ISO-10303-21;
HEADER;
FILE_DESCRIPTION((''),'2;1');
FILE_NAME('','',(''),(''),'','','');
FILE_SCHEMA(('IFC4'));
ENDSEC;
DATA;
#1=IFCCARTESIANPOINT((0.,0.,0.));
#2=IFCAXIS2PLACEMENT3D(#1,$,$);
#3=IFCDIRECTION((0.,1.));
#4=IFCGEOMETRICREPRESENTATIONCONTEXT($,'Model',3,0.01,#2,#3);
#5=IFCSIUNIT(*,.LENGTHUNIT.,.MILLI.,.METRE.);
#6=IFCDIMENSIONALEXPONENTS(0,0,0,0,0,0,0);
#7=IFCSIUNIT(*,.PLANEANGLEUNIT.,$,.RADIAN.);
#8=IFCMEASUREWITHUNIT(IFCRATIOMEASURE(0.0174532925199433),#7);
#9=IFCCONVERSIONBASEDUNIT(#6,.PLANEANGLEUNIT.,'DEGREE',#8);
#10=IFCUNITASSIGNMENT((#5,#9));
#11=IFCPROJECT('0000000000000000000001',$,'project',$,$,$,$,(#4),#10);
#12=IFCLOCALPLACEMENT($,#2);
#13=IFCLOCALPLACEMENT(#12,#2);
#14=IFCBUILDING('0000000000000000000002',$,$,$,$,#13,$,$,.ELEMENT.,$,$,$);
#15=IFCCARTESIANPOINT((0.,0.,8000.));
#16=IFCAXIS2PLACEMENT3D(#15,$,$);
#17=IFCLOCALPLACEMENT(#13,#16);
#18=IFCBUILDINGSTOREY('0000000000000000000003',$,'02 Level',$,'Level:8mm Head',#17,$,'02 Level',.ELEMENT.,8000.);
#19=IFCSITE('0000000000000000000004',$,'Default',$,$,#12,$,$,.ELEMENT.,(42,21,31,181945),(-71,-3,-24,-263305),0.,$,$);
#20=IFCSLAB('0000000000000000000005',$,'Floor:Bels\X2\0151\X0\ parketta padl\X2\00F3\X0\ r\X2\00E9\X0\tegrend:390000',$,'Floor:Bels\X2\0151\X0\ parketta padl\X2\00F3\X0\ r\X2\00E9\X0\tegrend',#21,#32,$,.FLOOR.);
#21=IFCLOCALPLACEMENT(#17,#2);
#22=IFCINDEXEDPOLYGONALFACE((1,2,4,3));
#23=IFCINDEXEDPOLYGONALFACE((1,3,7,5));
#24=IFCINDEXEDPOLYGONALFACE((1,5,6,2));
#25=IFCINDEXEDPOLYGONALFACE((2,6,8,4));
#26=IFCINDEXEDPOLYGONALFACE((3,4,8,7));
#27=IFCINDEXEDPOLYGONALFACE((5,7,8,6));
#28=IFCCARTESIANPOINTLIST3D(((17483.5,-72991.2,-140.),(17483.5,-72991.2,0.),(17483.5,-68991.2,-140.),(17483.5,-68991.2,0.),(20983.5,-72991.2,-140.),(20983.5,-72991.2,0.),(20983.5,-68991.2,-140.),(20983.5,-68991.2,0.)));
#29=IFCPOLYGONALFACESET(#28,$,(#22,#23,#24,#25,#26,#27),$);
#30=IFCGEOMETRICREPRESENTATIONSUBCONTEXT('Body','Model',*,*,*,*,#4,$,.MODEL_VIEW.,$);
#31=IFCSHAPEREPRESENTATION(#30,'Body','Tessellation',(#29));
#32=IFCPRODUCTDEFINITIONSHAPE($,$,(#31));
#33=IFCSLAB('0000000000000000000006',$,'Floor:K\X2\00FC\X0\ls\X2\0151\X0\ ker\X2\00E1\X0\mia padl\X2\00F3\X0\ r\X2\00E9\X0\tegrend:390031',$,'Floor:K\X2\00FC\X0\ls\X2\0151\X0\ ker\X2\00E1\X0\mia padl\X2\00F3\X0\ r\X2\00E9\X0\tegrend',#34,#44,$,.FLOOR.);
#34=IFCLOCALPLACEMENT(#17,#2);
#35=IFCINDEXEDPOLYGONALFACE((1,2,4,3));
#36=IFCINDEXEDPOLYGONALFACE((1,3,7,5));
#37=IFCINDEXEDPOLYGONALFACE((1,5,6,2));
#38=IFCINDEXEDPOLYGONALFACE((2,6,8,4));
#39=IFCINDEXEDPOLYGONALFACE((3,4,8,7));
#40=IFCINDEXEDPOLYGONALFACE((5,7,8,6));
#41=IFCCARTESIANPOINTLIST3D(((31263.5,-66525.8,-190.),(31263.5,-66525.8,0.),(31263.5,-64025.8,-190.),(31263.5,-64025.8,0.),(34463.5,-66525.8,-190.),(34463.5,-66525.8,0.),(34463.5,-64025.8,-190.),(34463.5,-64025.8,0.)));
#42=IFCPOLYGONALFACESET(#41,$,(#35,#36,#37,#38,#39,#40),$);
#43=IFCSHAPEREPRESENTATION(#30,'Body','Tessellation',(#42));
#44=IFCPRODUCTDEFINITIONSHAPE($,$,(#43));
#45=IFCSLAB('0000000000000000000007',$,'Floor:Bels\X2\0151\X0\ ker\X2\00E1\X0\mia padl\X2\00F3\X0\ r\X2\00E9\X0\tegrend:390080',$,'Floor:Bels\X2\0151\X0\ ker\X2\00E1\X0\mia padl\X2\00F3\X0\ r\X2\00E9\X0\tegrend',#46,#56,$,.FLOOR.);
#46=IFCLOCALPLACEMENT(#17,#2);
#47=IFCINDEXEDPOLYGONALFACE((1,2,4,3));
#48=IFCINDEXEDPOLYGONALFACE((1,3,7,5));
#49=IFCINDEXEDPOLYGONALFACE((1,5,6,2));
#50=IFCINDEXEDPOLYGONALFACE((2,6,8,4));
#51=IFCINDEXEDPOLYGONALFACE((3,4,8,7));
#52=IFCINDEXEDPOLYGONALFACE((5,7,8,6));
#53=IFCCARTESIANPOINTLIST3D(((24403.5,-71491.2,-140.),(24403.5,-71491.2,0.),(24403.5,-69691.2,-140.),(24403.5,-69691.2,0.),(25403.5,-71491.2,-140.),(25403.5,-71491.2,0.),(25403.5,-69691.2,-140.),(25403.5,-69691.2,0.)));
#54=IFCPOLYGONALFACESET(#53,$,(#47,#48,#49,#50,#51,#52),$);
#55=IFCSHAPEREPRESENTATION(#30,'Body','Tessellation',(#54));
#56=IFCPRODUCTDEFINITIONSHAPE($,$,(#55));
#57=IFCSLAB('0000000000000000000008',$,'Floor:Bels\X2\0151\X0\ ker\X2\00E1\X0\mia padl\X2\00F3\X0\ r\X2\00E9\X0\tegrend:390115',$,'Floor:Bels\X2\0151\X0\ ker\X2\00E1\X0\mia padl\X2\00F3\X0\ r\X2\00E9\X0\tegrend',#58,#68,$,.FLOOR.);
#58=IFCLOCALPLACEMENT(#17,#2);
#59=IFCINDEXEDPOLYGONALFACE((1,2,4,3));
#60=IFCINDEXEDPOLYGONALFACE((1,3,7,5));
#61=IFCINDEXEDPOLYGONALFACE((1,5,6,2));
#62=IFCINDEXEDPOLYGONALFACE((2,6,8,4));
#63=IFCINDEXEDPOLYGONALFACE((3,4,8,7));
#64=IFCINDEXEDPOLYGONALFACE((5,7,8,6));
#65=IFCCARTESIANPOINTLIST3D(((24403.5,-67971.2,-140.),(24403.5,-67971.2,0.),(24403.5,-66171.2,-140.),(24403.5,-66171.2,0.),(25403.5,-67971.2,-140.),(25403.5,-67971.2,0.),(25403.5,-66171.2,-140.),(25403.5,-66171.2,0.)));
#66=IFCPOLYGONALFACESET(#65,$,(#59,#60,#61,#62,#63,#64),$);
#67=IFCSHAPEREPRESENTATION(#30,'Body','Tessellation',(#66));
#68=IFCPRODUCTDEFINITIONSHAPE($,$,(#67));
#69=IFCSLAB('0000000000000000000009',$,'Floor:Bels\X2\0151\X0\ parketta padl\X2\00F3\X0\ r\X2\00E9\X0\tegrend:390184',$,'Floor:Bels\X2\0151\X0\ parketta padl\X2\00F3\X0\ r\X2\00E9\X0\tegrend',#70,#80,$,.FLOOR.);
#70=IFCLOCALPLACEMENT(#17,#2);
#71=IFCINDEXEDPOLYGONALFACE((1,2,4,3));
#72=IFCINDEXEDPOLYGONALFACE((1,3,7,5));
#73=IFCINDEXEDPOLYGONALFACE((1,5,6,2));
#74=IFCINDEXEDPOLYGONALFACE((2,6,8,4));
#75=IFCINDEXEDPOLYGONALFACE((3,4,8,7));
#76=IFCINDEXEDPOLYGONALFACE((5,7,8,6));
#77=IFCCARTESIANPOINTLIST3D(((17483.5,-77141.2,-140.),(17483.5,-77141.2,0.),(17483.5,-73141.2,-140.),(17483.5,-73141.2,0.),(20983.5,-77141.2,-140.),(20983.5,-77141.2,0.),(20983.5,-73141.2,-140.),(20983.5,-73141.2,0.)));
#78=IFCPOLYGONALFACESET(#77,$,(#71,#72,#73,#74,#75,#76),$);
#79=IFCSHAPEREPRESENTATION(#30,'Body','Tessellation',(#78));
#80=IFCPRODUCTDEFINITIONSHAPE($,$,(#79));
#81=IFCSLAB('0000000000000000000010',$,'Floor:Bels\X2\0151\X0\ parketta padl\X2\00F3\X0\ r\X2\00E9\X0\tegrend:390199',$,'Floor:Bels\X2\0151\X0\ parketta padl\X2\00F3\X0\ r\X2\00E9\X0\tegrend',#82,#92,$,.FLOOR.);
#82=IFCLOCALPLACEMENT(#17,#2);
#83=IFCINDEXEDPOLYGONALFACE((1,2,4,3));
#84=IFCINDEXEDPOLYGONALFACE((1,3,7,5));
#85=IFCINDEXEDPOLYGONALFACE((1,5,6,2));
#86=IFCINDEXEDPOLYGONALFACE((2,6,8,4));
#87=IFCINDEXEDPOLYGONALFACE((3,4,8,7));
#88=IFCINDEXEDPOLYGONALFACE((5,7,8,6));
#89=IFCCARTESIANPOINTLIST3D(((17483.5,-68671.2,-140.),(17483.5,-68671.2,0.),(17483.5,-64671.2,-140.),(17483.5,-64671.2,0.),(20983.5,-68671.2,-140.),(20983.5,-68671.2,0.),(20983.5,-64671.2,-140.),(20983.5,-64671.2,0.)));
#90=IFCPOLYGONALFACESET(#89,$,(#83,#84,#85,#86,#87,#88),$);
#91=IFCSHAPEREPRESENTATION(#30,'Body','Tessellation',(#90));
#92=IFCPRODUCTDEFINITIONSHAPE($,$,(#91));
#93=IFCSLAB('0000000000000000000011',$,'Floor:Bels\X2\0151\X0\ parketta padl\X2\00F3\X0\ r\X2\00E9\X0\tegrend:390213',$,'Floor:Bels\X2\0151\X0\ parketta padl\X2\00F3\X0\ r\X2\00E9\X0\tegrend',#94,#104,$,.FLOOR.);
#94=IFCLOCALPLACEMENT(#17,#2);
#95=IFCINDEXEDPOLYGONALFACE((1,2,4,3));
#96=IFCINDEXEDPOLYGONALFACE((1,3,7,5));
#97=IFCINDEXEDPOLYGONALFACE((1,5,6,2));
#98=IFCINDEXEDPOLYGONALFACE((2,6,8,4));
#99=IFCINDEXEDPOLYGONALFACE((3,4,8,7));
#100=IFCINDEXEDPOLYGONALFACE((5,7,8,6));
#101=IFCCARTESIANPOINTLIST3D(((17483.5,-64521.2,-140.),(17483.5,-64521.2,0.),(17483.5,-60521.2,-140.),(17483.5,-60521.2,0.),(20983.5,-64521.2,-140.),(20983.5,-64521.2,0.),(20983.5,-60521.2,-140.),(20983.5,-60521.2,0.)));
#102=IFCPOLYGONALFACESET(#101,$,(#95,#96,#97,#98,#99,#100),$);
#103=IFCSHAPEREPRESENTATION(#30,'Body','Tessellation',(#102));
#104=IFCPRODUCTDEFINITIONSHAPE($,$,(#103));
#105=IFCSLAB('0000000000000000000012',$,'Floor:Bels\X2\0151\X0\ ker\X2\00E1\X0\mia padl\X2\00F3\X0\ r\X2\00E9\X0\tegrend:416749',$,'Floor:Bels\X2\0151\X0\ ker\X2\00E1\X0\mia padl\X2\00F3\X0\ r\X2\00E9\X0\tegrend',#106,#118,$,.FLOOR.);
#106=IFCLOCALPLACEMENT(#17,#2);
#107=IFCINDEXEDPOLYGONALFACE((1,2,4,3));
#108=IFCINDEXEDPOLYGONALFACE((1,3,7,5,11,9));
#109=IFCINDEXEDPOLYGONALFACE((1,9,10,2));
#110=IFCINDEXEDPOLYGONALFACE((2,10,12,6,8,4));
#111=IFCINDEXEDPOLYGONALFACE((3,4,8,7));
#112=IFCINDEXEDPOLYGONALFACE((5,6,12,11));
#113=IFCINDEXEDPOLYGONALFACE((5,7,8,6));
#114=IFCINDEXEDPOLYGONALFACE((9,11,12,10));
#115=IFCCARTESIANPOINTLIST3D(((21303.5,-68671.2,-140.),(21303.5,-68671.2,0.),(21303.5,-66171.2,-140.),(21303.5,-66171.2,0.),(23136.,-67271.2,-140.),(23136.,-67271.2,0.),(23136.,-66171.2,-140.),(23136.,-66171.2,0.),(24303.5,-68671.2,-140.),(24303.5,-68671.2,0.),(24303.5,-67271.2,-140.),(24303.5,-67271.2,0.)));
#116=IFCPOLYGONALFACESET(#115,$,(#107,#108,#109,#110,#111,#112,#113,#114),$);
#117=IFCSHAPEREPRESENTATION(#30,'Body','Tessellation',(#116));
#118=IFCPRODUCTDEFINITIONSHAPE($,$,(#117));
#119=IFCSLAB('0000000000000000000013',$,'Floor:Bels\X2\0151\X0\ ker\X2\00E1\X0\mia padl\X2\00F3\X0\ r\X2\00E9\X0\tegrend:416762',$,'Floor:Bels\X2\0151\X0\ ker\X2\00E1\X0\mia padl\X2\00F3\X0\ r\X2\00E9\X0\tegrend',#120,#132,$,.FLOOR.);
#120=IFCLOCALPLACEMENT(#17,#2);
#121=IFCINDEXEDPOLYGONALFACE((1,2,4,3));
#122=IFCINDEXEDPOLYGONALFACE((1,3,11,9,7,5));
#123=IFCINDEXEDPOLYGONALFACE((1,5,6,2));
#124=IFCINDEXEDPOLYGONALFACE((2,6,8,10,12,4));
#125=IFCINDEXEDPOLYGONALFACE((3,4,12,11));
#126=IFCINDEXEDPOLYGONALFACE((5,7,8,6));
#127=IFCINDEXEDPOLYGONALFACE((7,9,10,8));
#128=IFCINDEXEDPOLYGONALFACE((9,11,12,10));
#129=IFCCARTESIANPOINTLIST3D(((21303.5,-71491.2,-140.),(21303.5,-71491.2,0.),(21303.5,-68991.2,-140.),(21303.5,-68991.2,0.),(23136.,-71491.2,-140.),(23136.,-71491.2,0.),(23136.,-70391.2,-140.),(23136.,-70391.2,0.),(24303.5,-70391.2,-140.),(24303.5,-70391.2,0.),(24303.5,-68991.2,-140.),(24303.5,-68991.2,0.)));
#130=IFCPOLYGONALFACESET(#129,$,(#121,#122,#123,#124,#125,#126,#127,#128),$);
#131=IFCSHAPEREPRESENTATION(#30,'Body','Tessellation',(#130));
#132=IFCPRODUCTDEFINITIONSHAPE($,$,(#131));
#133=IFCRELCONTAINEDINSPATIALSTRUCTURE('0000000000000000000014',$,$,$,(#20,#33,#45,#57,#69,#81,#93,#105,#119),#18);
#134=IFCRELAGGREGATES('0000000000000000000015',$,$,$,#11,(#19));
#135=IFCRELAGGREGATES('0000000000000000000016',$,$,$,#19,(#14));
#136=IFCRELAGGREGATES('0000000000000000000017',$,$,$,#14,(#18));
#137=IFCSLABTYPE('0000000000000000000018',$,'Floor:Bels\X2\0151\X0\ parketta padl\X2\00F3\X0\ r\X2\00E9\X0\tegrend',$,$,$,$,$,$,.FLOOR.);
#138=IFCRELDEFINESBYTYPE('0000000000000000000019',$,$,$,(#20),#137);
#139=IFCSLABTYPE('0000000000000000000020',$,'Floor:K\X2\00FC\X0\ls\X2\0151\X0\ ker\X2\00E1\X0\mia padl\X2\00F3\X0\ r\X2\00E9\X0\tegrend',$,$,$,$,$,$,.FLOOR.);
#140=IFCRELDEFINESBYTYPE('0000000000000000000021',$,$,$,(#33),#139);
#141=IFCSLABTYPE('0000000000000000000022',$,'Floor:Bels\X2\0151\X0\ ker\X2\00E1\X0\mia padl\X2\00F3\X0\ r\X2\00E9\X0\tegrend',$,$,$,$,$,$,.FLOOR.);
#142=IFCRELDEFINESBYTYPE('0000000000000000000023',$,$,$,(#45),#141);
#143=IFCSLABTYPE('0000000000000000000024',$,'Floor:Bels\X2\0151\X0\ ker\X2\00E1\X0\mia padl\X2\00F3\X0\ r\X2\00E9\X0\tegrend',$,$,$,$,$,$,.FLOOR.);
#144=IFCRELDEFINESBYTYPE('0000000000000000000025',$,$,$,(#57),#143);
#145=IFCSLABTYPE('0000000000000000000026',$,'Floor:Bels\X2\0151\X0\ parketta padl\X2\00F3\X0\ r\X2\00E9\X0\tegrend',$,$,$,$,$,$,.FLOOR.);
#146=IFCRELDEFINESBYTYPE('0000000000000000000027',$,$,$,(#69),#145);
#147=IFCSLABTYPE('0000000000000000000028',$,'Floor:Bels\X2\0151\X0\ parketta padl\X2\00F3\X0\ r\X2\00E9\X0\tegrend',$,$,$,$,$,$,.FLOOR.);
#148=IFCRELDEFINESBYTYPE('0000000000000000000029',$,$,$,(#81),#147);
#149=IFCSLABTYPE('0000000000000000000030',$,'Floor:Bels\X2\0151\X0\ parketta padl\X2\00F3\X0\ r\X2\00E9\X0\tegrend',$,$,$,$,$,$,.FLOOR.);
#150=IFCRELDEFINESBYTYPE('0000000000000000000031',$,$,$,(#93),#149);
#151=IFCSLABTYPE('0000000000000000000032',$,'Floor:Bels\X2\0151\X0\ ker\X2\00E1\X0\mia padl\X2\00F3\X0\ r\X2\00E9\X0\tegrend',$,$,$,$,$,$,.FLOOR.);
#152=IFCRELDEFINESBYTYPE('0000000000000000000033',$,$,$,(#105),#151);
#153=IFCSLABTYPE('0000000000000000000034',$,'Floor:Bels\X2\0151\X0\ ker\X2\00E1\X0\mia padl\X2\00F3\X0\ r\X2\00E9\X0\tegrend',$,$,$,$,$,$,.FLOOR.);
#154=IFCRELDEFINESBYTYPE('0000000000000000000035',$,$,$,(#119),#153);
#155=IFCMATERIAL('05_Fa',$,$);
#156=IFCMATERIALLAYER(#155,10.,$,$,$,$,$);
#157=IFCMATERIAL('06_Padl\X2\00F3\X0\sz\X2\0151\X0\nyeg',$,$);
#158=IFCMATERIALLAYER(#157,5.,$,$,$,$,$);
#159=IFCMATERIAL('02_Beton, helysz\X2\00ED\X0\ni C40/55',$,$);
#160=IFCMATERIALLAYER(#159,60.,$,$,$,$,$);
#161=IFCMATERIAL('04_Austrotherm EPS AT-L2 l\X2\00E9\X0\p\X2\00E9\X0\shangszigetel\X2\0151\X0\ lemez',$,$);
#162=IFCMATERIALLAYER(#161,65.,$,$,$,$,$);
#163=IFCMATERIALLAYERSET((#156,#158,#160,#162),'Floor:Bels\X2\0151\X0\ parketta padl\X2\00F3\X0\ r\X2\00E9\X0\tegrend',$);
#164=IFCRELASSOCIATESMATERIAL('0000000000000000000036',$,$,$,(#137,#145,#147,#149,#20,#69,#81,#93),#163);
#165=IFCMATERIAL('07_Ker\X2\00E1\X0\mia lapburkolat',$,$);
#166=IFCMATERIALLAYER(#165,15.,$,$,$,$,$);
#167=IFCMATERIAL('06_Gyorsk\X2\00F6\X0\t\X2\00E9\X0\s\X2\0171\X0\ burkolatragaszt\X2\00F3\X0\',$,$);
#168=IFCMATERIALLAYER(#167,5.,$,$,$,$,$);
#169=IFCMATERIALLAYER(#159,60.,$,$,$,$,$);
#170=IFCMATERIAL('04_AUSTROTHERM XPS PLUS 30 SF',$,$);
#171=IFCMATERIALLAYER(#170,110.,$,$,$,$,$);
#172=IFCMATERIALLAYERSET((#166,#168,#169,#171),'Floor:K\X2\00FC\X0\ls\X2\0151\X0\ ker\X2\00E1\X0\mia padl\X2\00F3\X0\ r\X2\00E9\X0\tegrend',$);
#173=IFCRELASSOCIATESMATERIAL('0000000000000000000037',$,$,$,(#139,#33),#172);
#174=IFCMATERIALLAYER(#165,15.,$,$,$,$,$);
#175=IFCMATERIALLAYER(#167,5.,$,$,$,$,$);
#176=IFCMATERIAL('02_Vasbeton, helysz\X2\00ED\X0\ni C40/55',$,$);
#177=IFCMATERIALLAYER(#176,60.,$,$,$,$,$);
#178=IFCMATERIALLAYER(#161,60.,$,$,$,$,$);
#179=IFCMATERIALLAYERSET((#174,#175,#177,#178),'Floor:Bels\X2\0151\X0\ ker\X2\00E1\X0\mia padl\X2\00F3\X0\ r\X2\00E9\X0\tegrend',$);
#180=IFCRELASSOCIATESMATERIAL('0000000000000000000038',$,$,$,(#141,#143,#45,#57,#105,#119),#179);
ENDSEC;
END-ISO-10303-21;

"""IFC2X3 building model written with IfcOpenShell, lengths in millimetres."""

from ifc_helpers import new_model, entity, si_unit, converted_unit, direction, frame, frame_2d, origin, origin_2d_with_axis, place, context, subcontext, project, spatial, polyline, rectangle, outline, extrude, material, layer, layer_set, layer_usage, type_object, element, save


model = new_model("IFC2X3")

# Units and contexts
model_context = context("Model", 3, precision=0.01, world=origin(), true_north=direction((0.0, 1.0)))
body_context = subcontext(model_context, "Body", "Model", "MODEL_VIEW")
ifc_project = project(units=[si_unit("LENGTHUNIT", "METRE", prefix="MILLI"), converted_unit("PLANEANGLEUNIT", "DEGREE", entity("IfcRatioMeasure", 0.0174532925199433), si_unit("PLANEANGLEUNIT", "RADIAN"), dimensions=[0, 0, 0, 0, 0, 0, 0])], contexts=[model_context])

# Site, building, storey
site_placement = place(None, origin())
site = spatial("IfcSite", under=ifc_project, at=site_placement, Name="Default", CompositionType="ELEMENT", RefLatitude=(42, 21, 31, 181945), RefLongitude=(-71, -3, -24, -263305), RefElevation=0.0)
building_placement = place(site_placement, origin())
building = spatial("IfcBuilding", under=site, at=building_placement, CompositionType="ELEMENT")
storey_placement = place(building_placement, frame((0.0, 0.0, 8000.0)))
storey = spatial("IfcBuildingStorey", under=building, at=storey_placement, Name="02 Level", ObjectType="Level:8mm Head", LongName="02 Level", CompositionType="ELEMENT", Elevation=8000.0)

# Slabs
ifc_material_1 = material(Name="05_Fa")
ifc_layer_1 = layer(ifc_material_1, 10.0)
ifc_material_2 = material(Name="06_Padlószőnyeg")
ifc_layer_2 = layer(ifc_material_2, 5.0)
ifc_material_3 = material(Name="02_Beton, helyszíni C40/55")
ifc_layer_3 = layer(ifc_material_3, 60.0)
ifc_material_4 = material(Name="04_Austrotherm EPS AT-L2 lépéshangszigetelő lemez")
ifc_layer_4 = layer(ifc_material_4, 65.0)
ifc_layer_set_1 = layer_set([ifc_layer_1, ifc_layer_2, ifc_layer_3, ifc_layer_4], Name="Floor:Belső parketta padló rétegrend")
ifc_layer_usage_1 = layer_usage(ifc_layer_set_1, "AXIS3", "POSITIVE", 0.0)
slab_type_1 = type_object("IfcSlabType", Name="Floor:Belső parketta padló rétegrend", PredefinedType="FLOOR", material=ifc_layer_set_1)
slab_1_placement = place(storey_placement, origin())
element("IfcSlab", 1, at=slab_1_placement, inside=storey, type_object=slab_type_1, material=ifc_layer_usage_1, Name="Floor:Belső parketta padló rétegrend:390000", ObjectType="Floor:Belső parketta padló rétegrend", PredefinedType="FLOOR", context=body_context, shape_type="SweptSolid", body=[
    extrude(rectangle(XDim=4000.0, YDim=3500.0, at=frame_2d((0.0, 0.0), x_axis=(1.0, 0.0))), frame((19233.5, -70991.2, 0.0), z_axis=(0.0, 0.0, -1.0), x_axis=(0.0, 1.0, 0.0)), (0.0, 0.0, 1.0), 140.0),
])
ifc_material_5 = material(Name="07_Kerámia lapburkolat")
ifc_layer_5 = layer(ifc_material_5, 15.0)
ifc_material_6 = material(Name="06_Gyorskötésű burkolatragasztó")
ifc_layer_6 = layer(ifc_material_6, 5.0)
ifc_layer_7 = layer(ifc_material_3, 60.0)
ifc_material_7 = material(Name="04_AUSTROTHERM XPS PLUS 30 SF")
ifc_layer_8 = layer(ifc_material_7, 110.0)
ifc_layer_set_2 = layer_set([ifc_layer_5, ifc_layer_6, ifc_layer_7, ifc_layer_8], Name="Floor:Külső kerámia padló rétegrend")
ifc_layer_usage_2 = layer_usage(ifc_layer_set_2, "AXIS3", "POSITIVE", 0.0)
slab_type_2 = type_object("IfcSlabType", Name="Floor:Külső kerámia padló rétegrend", PredefinedType="FLOOR", material=ifc_layer_set_2)
slab_2_placement = place(storey_placement, origin())
element("IfcSlab", 2, at=slab_2_placement, inside=storey, type_object=slab_type_2, material=ifc_layer_usage_2, Name="Floor:Külső kerámia padló rétegrend:390031", ObjectType="Floor:Külső kerámia padló rétegrend", PredefinedType="FLOOR", context=body_context, shape_type="SweptSolid", body=[
    extrude(rectangle(XDim=2500.0, YDim=3200.0, at=origin_2d_with_axis()), frame((32863.5, -65275.8, 0.0), z_axis=(0.0, 0.0, -1.0), x_axis=(0.0, 1.0, 0.0)), (0.0, 0.0, 1.0), 190.0),
])
ifc_layer_9 = layer(ifc_material_5, 15.0)
ifc_layer_10 = layer(ifc_material_6, 5.0)
ifc_material_8 = material(Name="02_Vasbeton, helyszíni C40/55")
ifc_layer_11 = layer(ifc_material_8, 60.0)
ifc_layer_12 = layer(ifc_material_4, 60.0)
ifc_layer_set_3 = layer_set([ifc_layer_9, ifc_layer_10, ifc_layer_11, ifc_layer_12], Name="Floor:Belső kerámia padló rétegrend")
ifc_layer_usage_3 = layer_usage(ifc_layer_set_3, "AXIS3", "POSITIVE", 0.0)
slab_type_3 = type_object("IfcSlabType", Name="Floor:Belső kerámia padló rétegrend", PredefinedType="FLOOR", material=ifc_layer_set_3)
slab_3_placement = place(storey_placement, origin())
element("IfcSlab", 3, at=slab_3_placement, inside=storey, type_object=slab_type_3, material=ifc_layer_usage_3, Name="Floor:Belső kerámia padló rétegrend:390080", ObjectType="Floor:Belső kerámia padló rétegrend", PredefinedType="FLOOR", context=body_context, shape_type="SweptSolid", body=[
    extrude(rectangle(XDim=1800.0, YDim=1000.0, at=frame_2d((0.0, 0.0), x_axis=(1.0, 0.0))), frame((24903.5, -70591.2, 0.0), z_axis=(0.0, 0.0, -1.0), x_axis=(0.0, 1.0, 0.0)), (0.0, 0.0, 1.0), 140.0),
])
ifc_layer_usage_4 = layer_usage(ifc_layer_set_3, "AXIS3", "POSITIVE", 0.0)
slab_type_4 = type_object("IfcSlabType", Name="Floor:Belső kerámia padló rétegrend", PredefinedType="FLOOR", material=ifc_layer_set_3)
slab_4_placement = place(storey_placement, origin())
element("IfcSlab", 4, at=slab_4_placement, inside=storey, type_object=slab_type_4, material=ifc_layer_usage_4, Name="Floor:Belső kerámia padló rétegrend:390115", ObjectType="Floor:Belső kerámia padló rétegrend", PredefinedType="FLOOR", context=body_context, shape_type="SweptSolid", body=[
    extrude(rectangle(XDim=1800.0, YDim=1000.0, at=frame_2d((0.0, 0.0), x_axis=(1.0, 0.0))), frame((24903.5, -67071.2, 0.0), z_axis=(0.0, 0.0, -1.0), x_axis=(0.0, 1.0, 0.0)), (0.0, 0.0, 1.0), 140.0),
])
ifc_layer_usage_5 = layer_usage(ifc_layer_set_1, "AXIS3", "POSITIVE", 0.0)
slab_type_5 = type_object("IfcSlabType", Name="Floor:Belső parketta padló rétegrend", PredefinedType="FLOOR", material=ifc_layer_set_1)
slab_5_placement = place(storey_placement, origin())
element("IfcSlab", 5, at=slab_5_placement, inside=storey, type_object=slab_type_5, material=ifc_layer_usage_5, Name="Floor:Belső parketta padló rétegrend:390184", ObjectType="Floor:Belső parketta padló rétegrend", PredefinedType="FLOOR", context=body_context, shape_type="SweptSolid", body=[
    extrude(rectangle(XDim=4000.0, YDim=3500.0, at=frame_2d((0.0, 0.0), x_axis=(1.0, 0.0))), frame((19233.5, -75141.2, 0.0), z_axis=(0.0, 0.0, -1.0), x_axis=(0.0, 1.0, 0.0)), (0.0, 0.0, 1.0), 140.0),
])
ifc_layer_usage_6 = layer_usage(ifc_layer_set_1, "AXIS3", "POSITIVE", 0.0)
slab_type_6 = type_object("IfcSlabType", Name="Floor:Belső parketta padló rétegrend", PredefinedType="FLOOR", material=ifc_layer_set_1)
slab_6_placement = place(storey_placement, origin())
element("IfcSlab", 6, at=slab_6_placement, inside=storey, type_object=slab_type_6, material=ifc_layer_usage_6, Name="Floor:Belső parketta padló rétegrend:390199", ObjectType="Floor:Belső parketta padló rétegrend", PredefinedType="FLOOR", context=body_context, shape_type="SweptSolid", body=[
    extrude(rectangle(XDim=4000.0, YDim=3500.0, at=frame_2d((0.0, 0.0), x_axis=(1.0, 0.0))), frame((19233.5, -66671.2, 0.0), z_axis=(0.0, 0.0, -1.0), x_axis=(0.0, 1.0, 0.0)), (0.0, 0.0, 1.0), 140.0),
])
ifc_layer_usage_7 = layer_usage(ifc_layer_set_1, "AXIS3", "POSITIVE", 0.0)
slab_type_7 = type_object("IfcSlabType", Name="Floor:Belső parketta padló rétegrend", PredefinedType="FLOOR", material=ifc_layer_set_1)
slab_7_placement = place(storey_placement, origin())
element("IfcSlab", 7, at=slab_7_placement, inside=storey, type_object=slab_type_7, material=ifc_layer_usage_7, Name="Floor:Belső parketta padló rétegrend:390213", ObjectType="Floor:Belső parketta padló rétegrend", PredefinedType="FLOOR", context=body_context, shape_type="SweptSolid", body=[
    extrude(rectangle(XDim=4000.0, YDim=3500.0, at=frame_2d((0.0, 0.0), x_axis=(1.0, 0.0))), frame((19233.5, -62521.2, 0.0), z_axis=(0.0, 0.0, -1.0), x_axis=(0.0, 1.0, 0.0)), (0.0, 0.0, 1.0), 140.0),
])
ifc_layer_usage_8 = layer_usage(ifc_layer_set_3, "AXIS3", "POSITIVE", 0.0)
slab_type_8 = type_object("IfcSlabType", Name="Floor:Belső kerámia padló rétegrend", PredefinedType="FLOOR")
slab_8_placement = place(storey_placement, frame((21303.5, -68671.2, -140.0)))
element("IfcSlab", 8, at=slab_8_placement, inside=storey, type_object=slab_type_8, material=ifc_layer_usage_8, Name="Floor:Belső kerámia padló rétegrend:416749", ObjectType="Floor:Belső kerámia padló rétegrend", PredefinedType="FLOOR", context=body_context, shape_type="SweptSolid", body=[
    extrude(outline(polyline([(-1500.0, -1250.0), (1500.0, -1250.0), (1500.0, 1250.0), (-332.5, 1250.0), (-332.5, 150.0), (-1500.0, 150.0), (-1500.0, -1250.0)])), frame((1500.0, 1250.0, 140.0), z_axis=(0.0, 0.0, -1.0), x_axis=(-1.0, 0.0, 0.0)), (0.0, 0.0, 1.0), 140.0),
])
ifc_layer_usage_9 = layer_usage(ifc_layer_set_3, "AXIS3", "POSITIVE", 0.0)
slab_type_9 = type_object("IfcSlabType", Name="Floor:Belső kerámia padló rétegrend", PredefinedType="FLOOR")
slab_9_placement = place(storey_placement, frame((21303.5, -71491.2, -140.0)))
element("IfcSlab", 9, at=slab_9_placement, inside=storey, type_object=slab_type_9, material=ifc_layer_usage_9, Name="Floor:Belső kerámia padló rétegrend:416762", ObjectType="Floor:Belső kerámia padló rétegrend", PredefinedType="FLOOR", context=body_context, shape_type="SweptSolid", body=[
    extrude(outline(polyline([(-1500.0, 1250.0), (-1500.0, -150.0), (-332.5, -150.0), (-332.5, -1250.0), (1500.0, -1250.0), (1500.0, 1250.0), (-1500.0, 1250.0)])), frame((1500.0, 1250.0, 140.0), z_axis=(0.0, 0.0, -1.0), x_axis=(-1.0, 0.0, 0.0)), (0.0, 0.0, 1.0), 140.0),
])

save(model, "model.ifc")
